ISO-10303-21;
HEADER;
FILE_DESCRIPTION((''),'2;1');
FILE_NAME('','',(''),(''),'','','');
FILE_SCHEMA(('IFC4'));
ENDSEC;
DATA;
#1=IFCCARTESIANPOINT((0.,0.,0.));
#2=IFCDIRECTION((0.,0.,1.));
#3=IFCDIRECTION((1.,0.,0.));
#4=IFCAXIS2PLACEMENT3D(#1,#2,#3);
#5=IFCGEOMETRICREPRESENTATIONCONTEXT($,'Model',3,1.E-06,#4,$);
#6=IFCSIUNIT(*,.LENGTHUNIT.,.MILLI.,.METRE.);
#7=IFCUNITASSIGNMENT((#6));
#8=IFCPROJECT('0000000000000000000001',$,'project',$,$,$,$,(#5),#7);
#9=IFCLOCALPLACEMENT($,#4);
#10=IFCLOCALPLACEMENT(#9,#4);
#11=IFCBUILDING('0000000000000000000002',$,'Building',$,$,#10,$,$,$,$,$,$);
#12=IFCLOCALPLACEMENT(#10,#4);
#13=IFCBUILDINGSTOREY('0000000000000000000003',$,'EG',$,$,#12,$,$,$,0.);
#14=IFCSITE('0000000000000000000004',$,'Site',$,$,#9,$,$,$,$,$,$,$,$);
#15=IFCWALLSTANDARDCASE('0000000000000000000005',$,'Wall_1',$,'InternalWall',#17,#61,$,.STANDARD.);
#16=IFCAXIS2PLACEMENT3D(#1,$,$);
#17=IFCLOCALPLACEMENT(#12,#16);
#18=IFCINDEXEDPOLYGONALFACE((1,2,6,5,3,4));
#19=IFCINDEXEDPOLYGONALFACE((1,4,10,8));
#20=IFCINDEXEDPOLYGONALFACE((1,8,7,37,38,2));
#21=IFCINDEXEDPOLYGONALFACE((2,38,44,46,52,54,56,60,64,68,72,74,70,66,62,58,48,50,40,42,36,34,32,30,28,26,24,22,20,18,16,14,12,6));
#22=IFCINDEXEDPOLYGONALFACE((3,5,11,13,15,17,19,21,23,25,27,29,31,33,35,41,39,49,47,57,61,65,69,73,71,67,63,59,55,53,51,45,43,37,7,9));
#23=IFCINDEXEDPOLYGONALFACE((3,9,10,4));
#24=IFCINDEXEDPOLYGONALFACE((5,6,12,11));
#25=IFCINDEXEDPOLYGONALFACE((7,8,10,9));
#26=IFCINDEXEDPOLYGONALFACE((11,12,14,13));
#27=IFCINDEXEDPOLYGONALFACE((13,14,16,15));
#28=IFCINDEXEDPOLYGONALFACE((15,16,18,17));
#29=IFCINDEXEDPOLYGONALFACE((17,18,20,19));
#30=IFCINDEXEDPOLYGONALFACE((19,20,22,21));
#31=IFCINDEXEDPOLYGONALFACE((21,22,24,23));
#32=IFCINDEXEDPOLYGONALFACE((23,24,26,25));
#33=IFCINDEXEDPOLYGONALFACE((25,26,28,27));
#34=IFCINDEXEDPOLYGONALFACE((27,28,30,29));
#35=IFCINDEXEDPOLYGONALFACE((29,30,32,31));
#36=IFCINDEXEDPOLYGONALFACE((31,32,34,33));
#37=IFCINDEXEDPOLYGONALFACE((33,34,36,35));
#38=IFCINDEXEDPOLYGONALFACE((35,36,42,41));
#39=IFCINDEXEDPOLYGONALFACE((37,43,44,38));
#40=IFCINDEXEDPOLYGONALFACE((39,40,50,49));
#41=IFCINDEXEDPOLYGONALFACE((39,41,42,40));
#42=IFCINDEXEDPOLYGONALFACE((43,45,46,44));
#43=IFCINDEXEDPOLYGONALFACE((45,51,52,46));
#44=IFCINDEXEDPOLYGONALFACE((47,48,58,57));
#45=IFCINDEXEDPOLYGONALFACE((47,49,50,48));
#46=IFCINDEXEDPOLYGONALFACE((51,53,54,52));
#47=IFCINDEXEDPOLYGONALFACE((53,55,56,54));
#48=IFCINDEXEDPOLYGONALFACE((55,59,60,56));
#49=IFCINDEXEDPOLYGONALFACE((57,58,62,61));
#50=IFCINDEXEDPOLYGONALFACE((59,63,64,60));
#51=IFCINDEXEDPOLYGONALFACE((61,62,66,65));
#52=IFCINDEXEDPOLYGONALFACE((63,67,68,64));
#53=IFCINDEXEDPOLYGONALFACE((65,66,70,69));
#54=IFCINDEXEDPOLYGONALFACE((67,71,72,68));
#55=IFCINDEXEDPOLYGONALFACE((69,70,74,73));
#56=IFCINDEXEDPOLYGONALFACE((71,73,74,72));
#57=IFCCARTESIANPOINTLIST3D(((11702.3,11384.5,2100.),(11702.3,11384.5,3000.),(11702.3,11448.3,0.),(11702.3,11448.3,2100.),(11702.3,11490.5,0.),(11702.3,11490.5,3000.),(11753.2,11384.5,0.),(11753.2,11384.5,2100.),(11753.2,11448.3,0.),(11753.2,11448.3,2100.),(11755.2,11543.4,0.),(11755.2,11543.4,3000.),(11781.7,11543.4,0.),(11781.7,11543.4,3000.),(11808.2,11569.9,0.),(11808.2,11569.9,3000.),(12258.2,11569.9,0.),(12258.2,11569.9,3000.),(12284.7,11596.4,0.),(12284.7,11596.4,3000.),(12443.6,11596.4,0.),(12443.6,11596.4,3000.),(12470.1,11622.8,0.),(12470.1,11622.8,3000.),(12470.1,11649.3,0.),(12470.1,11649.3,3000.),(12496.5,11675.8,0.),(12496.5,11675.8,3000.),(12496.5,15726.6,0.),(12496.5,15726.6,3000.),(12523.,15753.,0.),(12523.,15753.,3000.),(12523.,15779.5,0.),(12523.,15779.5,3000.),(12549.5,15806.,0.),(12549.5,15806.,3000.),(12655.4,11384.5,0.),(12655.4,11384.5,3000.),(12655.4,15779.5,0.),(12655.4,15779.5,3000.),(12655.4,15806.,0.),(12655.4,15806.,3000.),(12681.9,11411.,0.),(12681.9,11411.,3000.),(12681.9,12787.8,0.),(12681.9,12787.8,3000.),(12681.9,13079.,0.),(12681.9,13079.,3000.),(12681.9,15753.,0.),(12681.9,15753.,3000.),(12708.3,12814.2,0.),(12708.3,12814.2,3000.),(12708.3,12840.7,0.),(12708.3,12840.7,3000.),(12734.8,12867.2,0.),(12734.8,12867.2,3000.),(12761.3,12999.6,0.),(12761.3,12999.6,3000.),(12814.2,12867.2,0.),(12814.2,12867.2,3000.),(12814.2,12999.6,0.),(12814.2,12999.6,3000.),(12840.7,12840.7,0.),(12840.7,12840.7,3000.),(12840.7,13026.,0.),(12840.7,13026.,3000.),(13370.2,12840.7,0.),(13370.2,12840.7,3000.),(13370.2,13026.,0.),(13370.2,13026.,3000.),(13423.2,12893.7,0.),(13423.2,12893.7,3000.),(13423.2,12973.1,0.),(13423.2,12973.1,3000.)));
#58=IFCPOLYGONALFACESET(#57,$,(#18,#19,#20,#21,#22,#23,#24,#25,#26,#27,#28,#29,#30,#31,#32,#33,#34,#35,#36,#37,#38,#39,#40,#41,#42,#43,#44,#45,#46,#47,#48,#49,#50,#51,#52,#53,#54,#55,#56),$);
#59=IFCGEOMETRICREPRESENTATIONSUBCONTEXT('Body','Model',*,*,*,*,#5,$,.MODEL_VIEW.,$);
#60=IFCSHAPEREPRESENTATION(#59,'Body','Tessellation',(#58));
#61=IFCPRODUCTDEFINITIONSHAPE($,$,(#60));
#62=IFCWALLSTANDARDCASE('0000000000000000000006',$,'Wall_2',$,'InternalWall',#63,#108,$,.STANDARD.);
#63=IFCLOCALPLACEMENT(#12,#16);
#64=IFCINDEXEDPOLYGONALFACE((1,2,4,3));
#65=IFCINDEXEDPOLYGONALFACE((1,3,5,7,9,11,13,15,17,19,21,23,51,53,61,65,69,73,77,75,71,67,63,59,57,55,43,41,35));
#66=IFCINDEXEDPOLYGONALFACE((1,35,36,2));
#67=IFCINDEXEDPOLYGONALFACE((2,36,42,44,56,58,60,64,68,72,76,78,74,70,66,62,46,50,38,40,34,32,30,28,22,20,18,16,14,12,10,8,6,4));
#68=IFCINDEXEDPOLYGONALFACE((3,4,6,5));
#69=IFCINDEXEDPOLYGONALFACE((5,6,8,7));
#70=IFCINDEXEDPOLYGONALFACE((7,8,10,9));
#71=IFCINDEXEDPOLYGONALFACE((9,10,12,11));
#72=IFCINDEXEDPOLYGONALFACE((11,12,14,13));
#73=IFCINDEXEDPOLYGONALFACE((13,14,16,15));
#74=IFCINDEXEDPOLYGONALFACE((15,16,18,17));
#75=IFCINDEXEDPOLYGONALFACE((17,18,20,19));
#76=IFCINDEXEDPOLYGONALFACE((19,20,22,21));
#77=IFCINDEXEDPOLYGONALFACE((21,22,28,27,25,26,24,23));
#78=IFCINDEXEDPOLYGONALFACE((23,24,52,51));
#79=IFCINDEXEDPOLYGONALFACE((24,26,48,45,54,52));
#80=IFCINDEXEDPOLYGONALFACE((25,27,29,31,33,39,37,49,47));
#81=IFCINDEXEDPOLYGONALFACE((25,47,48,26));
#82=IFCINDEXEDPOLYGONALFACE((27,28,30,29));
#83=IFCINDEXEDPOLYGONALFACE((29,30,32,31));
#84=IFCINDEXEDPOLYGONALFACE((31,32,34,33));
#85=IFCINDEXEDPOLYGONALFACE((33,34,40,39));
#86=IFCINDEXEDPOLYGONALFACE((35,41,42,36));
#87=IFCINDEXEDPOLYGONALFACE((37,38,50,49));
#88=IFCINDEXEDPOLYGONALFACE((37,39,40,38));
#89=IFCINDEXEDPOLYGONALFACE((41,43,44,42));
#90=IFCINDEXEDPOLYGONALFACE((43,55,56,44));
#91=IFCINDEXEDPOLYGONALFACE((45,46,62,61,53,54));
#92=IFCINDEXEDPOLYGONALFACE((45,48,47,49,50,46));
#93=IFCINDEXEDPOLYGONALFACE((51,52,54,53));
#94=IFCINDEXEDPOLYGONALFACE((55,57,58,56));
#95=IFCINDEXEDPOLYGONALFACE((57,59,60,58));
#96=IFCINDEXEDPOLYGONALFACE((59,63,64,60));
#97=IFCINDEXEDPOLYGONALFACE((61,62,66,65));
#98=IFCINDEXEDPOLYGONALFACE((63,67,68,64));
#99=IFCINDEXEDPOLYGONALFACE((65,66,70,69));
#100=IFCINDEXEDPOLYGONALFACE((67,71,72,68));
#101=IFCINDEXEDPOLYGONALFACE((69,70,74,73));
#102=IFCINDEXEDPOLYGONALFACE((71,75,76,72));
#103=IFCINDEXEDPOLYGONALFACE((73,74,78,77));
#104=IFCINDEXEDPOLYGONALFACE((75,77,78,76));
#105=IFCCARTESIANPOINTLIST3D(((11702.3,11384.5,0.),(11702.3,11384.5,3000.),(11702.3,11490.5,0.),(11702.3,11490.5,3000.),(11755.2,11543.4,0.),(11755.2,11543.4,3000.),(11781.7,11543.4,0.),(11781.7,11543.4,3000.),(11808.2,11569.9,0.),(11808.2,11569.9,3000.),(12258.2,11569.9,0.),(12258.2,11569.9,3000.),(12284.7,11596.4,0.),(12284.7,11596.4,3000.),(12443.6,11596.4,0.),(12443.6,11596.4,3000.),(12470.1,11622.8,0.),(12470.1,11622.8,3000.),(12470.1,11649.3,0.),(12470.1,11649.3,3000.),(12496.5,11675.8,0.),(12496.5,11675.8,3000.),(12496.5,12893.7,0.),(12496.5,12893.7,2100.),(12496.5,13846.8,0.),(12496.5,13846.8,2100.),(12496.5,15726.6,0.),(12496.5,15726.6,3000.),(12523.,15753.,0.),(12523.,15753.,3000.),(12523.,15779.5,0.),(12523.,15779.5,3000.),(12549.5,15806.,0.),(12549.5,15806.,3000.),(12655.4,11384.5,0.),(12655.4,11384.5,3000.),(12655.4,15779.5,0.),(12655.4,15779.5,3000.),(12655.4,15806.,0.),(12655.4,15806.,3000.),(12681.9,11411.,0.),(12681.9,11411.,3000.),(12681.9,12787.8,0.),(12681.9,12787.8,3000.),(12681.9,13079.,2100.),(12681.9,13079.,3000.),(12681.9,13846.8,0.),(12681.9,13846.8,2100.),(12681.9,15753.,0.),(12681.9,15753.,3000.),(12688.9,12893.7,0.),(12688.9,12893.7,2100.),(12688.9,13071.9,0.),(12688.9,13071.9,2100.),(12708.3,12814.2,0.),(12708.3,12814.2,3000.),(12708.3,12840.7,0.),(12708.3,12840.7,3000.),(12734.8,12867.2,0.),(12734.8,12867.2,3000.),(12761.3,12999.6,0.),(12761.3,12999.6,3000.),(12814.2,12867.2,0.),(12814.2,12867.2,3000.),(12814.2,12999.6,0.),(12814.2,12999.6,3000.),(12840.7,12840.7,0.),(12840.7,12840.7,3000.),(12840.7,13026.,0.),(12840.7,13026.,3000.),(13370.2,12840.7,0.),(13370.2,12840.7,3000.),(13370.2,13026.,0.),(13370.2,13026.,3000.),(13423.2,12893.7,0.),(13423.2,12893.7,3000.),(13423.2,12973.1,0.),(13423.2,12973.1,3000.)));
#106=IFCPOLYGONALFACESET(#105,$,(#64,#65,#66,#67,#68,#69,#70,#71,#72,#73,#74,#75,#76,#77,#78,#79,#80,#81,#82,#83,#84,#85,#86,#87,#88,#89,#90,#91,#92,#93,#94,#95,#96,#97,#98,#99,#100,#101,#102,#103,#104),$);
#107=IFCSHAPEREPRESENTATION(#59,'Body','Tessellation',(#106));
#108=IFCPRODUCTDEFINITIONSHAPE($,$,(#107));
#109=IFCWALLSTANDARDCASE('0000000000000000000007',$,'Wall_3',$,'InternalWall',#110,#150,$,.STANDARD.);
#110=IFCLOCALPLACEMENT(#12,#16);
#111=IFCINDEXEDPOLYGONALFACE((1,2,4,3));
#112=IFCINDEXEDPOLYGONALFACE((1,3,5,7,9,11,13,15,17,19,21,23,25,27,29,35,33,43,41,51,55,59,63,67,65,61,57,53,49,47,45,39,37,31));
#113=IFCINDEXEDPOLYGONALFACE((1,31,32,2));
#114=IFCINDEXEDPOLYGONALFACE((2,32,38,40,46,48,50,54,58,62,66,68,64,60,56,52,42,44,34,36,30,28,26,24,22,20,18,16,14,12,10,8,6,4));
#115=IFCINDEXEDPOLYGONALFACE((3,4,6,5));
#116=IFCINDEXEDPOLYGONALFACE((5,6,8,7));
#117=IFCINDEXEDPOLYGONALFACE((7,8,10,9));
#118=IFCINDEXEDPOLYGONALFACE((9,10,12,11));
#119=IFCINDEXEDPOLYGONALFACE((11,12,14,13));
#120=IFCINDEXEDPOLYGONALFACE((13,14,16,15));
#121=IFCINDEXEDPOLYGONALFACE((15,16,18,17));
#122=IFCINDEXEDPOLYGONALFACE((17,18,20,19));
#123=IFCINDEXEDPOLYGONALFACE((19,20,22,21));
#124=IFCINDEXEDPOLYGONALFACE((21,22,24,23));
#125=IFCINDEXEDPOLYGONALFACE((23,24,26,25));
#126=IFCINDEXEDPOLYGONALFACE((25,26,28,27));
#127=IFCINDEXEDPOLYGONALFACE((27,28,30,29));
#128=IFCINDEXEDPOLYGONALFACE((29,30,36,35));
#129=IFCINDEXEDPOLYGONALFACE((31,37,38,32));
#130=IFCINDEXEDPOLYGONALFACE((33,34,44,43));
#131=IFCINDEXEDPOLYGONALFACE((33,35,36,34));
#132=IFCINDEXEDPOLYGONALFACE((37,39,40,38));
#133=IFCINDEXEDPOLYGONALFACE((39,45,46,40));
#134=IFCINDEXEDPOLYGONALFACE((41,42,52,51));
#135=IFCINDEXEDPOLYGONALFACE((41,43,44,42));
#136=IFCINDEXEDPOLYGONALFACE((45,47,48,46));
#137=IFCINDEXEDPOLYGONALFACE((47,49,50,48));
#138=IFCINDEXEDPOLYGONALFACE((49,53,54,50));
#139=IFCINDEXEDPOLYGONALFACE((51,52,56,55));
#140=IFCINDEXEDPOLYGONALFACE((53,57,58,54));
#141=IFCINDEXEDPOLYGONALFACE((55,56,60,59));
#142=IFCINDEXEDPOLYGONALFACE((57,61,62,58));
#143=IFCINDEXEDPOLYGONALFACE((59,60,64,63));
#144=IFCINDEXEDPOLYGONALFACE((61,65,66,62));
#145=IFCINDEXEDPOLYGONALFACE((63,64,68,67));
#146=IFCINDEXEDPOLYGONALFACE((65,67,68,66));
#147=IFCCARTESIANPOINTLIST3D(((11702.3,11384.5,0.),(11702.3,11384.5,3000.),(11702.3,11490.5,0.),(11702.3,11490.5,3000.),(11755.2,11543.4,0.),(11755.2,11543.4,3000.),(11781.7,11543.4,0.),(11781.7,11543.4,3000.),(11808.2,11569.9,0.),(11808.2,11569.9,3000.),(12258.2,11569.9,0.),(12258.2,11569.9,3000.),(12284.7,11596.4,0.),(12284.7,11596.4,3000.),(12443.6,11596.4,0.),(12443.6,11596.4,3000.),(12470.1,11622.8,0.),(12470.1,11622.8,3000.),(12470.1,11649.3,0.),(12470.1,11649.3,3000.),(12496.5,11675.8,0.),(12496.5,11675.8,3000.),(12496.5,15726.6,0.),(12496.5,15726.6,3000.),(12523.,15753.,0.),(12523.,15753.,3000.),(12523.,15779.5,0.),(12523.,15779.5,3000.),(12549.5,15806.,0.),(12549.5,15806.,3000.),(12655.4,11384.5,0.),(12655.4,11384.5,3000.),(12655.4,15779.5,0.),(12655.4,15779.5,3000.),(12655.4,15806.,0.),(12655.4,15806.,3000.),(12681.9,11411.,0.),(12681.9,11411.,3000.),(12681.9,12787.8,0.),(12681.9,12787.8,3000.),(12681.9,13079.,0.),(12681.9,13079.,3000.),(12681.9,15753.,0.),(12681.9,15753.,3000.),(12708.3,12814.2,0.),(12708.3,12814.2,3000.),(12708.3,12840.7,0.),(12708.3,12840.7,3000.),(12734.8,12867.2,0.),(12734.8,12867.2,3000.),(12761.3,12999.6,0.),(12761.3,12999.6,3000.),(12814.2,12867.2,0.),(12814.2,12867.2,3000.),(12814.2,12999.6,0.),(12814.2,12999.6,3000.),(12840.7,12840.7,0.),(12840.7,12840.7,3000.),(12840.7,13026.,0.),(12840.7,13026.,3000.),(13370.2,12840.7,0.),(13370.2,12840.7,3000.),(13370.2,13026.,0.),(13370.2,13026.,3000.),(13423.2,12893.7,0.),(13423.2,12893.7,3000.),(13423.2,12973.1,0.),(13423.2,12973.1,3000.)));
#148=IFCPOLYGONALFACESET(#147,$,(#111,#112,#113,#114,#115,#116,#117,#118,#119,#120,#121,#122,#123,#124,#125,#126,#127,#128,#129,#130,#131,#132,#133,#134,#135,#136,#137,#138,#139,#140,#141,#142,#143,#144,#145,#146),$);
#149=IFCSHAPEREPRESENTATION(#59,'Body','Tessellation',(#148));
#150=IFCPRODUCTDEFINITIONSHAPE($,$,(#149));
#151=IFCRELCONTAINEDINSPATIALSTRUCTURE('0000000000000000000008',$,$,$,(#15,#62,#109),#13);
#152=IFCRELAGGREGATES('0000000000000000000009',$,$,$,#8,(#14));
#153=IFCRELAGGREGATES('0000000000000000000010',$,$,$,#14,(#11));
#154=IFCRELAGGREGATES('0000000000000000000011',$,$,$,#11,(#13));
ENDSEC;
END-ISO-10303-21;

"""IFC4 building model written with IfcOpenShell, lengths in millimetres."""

from ifc_helpers import new_model, si_unit, frame, origin_with_axes, place, context, subcontext, project, spatial, polyline, rectangle, outline, extrude, element, save


model = new_model("IFC4")

# Units and contexts
model_context = context("Model", 3, precision=1e-06, world=origin_with_axes())
body_context = subcontext(model_context, "Body", "Model", "MODEL_VIEW")
ifc_project = project(units=[si_unit("LENGTHUNIT", "METRE", prefix="MILLI")], contexts=[model_context])

# Site, building, storey
site_placement = place(None, origin_with_axes())
site = spatial("IfcSite", under=ifc_project, at=site_placement, Name="Site")
building_placement = place(site_placement, origin_with_axes())
building = spatial("IfcBuilding", under=site, at=building_placement, Name="Building")
storey_placement = place(building_placement, origin_with_axes())
storey = spatial("IfcBuildingStorey", under=building, at=storey_placement, Name="EG", Elevation=0.0)

# Walls, openings
wall_1_placement = place(storey_placement, origin_with_axes())
wall_1 = element("IfcWallStandardCase", 1, at=wall_1_placement, inside=storey, Name="Wall_1", ObjectType="InternalWall", PredefinedType="STANDARD", context=body_context, shape_type="SweptSolid", body=[
    extrude(outline(polyline([(11702.3, 11384.5, 0.0), (11702.3, 11490.5, 0.0), (11755.2, 11543.4, 0.0), (11781.7, 11543.4, 0.0), (11808.2, 11569.9, 0.0), (12258.2, 11569.9, 0.0), (12284.7, 11596.4, 0.0), (12443.6, 11596.4, 0.0), (12470.1, 11622.8, 0.0), (12470.1, 11649.3, 0.0), (12496.5, 11675.8, 0.0), (12496.5, 15726.6, 0.0), (12523.0, 15753.0, 0.0), (12523.0, 15779.5, 0.0), (12549.5, 15806.0, 0.0), (12655.4, 15806.0, 0.0), (12655.4, 15779.5, 0.0), (12681.9, 15753.0, 0.0), (12681.9, 13079.0, 0.0), (12761.3, 12999.6, 0.0), (12814.2, 12999.6, 0.0), (12840.7, 13026.0, 0.0), (13370.2, 13026.0, 0.0), (13423.2, 12973.1, 0.0), (13423.2, 12893.7, 0.0), (13370.2, 12840.7, 0.0), (12840.7, 12840.7, 0.0), (12814.2, 12867.2, 0.0), (12734.8, 12867.2, 0.0), (12708.3, 12840.7, 0.0), (12708.3, 12814.2, 0.0), (12681.9, 12787.8, 0.0), (12681.9, 11411.0, 0.0), (12655.4, 11384.5, 0.0), (11702.3, 11384.5, 0.0)])), origin_with_axes(), (0.0, 0.0, 1.0), 3000.0),
])
opening_1_placement = place(wall_1_placement, origin_with_axes())
element("IfcOpeningElement", 2, at=opening_1_placement, inside=storey, cuts=wall_1, context=body_context, shape_type="SweptSolid", body=[
    extrude(rectangle(XDim=915.1, YDim=240.0), frame((11295.7, 11328.3, 0.0), z_axis=(0.0, 0.0, 1.0), x_axis=(1.0, 0.0, 0.0)), (0.0, 0.0, 1.0), 2100.0),
])
wall_2_placement = place(storey_placement, origin_with_axes())
wall_2 = element("IfcWallStandardCase", 3, at=wall_2_placement, inside=storey, Name="Wall_2", ObjectType="InternalWall", PredefinedType="STANDARD", context=body_context, shape_type="SweptSolid", body=[
    extrude(outline(polyline([(11702.3, 11384.5, 0.0), (11702.3, 11490.5, 0.0), (11755.2, 11543.4, 0.0), (11781.7, 11543.4, 0.0), (11808.2, 11569.9, 0.0), (12258.2, 11569.9, 0.0), (12284.7, 11596.4, 0.0), (12443.6, 11596.4, 0.0), (12470.1, 11622.8, 0.0), (12470.1, 11649.3, 0.0), (12496.5, 11675.8, 0.0), (12496.5, 15726.6, 0.0), (12523.0, 15753.0, 0.0), (12523.0, 15779.5, 0.0), (12549.5, 15806.0, 0.0), (12655.4, 15806.0, 0.0), (12655.4, 15779.5, 0.0), (12681.9, 15753.0, 0.0), (12681.9, 13079.0, 0.0), (12761.3, 12999.6, 0.0), (12814.2, 12999.6, 0.0), (12840.7, 13026.0, 0.0), (13370.2, 13026.0, 0.0), (13423.2, 12973.1, 0.0), (13423.2, 12893.7, 0.0), (13370.2, 12840.7, 0.0), (12840.7, 12840.7, 0.0), (12814.2, 12867.2, 0.0), (12734.8, 12867.2, 0.0), (12708.3, 12840.7, 0.0), (12708.3, 12814.2, 0.0), (12681.9, 12787.8, 0.0), (12681.9, 11411.0, 0.0), (12655.4, 11384.5, 0.0), (11702.3, 11384.5, 0.0)])), origin_with_axes(), (0.0, 0.0, 1.0), 3000.0),
])
opening_2_placement = place(wall_2_placement, origin_with_axes())
element("IfcOpeningElement", 4, at=opening_2_placement, inside=storey, cuts=wall_2, context=body_context, shape_type="SweptSolid", body=[
    extrude(rectangle(XDim=953.1, YDim=240.0), frame((12568.9, 13370.2, 0.0), z_axis=(0.0, 0.0, 1.0), x_axis=(0.0, 1.0, 0.0)), (0.0, 0.0, 1.0), 2100.0),
])

# Wall
for number, where, z_axis, x_axis, name in (
    (5, (0.0, 0.0, 0.0), (0.0, 0.0, 1.0), (1.0, 0.0, 0.0), "Wall_3"),
):
    element("IfcWallStandardCase", number, at=place(storey_placement, frame(where, z_axis=z_axis, x_axis=x_axis)), inside=storey, Name=name, ObjectType="InternalWall", PredefinedType="STANDARD", context=body_context, shape_type="SweptSolid", body=[
        extrude(outline(polyline([(11702.3, 11384.5, 0.0), (11702.3, 11490.5, 0.0), (11755.2, 11543.4, 0.0), (11781.7, 11543.4, 0.0), (11808.2, 11569.9, 0.0), (12258.2, 11569.9, 0.0), (12284.7, 11596.4, 0.0), (12443.6, 11596.4, 0.0), (12470.1, 11622.8, 0.0), (12470.1, 11649.3, 0.0), (12496.5, 11675.8, 0.0), (12496.5, 15726.6, 0.0), (12523.0, 15753.0, 0.0), (12523.0, 15779.5, 0.0), (12549.5, 15806.0, 0.0), (12655.4, 15806.0, 0.0), (12655.4, 15779.5, 0.0), (12681.9, 15753.0, 0.0), (12681.9, 13079.0, 0.0), (12761.3, 12999.6, 0.0), (12814.2, 12999.6, 0.0), (12840.7, 13026.0, 0.0), (13370.2, 13026.0, 0.0), (13423.2, 12973.1, 0.0), (13423.2, 12893.7, 0.0), (13370.2, 12840.7, 0.0), (12840.7, 12840.7, 0.0), (12814.2, 12867.2, 0.0), (12734.8, 12867.2, 0.0), (12708.3, 12840.7, 0.0), (12708.3, 12814.2, 0.0), (12681.9, 12787.8, 0.0), (12681.9, 11411.0, 0.0), (12655.4, 11384.5, 0.0), (11702.3, 11384.5, 0.0)])), origin_with_axes(), (0.0, 0.0, 1.0), 3000.0),
    ])

save(model, "model.ifc")
